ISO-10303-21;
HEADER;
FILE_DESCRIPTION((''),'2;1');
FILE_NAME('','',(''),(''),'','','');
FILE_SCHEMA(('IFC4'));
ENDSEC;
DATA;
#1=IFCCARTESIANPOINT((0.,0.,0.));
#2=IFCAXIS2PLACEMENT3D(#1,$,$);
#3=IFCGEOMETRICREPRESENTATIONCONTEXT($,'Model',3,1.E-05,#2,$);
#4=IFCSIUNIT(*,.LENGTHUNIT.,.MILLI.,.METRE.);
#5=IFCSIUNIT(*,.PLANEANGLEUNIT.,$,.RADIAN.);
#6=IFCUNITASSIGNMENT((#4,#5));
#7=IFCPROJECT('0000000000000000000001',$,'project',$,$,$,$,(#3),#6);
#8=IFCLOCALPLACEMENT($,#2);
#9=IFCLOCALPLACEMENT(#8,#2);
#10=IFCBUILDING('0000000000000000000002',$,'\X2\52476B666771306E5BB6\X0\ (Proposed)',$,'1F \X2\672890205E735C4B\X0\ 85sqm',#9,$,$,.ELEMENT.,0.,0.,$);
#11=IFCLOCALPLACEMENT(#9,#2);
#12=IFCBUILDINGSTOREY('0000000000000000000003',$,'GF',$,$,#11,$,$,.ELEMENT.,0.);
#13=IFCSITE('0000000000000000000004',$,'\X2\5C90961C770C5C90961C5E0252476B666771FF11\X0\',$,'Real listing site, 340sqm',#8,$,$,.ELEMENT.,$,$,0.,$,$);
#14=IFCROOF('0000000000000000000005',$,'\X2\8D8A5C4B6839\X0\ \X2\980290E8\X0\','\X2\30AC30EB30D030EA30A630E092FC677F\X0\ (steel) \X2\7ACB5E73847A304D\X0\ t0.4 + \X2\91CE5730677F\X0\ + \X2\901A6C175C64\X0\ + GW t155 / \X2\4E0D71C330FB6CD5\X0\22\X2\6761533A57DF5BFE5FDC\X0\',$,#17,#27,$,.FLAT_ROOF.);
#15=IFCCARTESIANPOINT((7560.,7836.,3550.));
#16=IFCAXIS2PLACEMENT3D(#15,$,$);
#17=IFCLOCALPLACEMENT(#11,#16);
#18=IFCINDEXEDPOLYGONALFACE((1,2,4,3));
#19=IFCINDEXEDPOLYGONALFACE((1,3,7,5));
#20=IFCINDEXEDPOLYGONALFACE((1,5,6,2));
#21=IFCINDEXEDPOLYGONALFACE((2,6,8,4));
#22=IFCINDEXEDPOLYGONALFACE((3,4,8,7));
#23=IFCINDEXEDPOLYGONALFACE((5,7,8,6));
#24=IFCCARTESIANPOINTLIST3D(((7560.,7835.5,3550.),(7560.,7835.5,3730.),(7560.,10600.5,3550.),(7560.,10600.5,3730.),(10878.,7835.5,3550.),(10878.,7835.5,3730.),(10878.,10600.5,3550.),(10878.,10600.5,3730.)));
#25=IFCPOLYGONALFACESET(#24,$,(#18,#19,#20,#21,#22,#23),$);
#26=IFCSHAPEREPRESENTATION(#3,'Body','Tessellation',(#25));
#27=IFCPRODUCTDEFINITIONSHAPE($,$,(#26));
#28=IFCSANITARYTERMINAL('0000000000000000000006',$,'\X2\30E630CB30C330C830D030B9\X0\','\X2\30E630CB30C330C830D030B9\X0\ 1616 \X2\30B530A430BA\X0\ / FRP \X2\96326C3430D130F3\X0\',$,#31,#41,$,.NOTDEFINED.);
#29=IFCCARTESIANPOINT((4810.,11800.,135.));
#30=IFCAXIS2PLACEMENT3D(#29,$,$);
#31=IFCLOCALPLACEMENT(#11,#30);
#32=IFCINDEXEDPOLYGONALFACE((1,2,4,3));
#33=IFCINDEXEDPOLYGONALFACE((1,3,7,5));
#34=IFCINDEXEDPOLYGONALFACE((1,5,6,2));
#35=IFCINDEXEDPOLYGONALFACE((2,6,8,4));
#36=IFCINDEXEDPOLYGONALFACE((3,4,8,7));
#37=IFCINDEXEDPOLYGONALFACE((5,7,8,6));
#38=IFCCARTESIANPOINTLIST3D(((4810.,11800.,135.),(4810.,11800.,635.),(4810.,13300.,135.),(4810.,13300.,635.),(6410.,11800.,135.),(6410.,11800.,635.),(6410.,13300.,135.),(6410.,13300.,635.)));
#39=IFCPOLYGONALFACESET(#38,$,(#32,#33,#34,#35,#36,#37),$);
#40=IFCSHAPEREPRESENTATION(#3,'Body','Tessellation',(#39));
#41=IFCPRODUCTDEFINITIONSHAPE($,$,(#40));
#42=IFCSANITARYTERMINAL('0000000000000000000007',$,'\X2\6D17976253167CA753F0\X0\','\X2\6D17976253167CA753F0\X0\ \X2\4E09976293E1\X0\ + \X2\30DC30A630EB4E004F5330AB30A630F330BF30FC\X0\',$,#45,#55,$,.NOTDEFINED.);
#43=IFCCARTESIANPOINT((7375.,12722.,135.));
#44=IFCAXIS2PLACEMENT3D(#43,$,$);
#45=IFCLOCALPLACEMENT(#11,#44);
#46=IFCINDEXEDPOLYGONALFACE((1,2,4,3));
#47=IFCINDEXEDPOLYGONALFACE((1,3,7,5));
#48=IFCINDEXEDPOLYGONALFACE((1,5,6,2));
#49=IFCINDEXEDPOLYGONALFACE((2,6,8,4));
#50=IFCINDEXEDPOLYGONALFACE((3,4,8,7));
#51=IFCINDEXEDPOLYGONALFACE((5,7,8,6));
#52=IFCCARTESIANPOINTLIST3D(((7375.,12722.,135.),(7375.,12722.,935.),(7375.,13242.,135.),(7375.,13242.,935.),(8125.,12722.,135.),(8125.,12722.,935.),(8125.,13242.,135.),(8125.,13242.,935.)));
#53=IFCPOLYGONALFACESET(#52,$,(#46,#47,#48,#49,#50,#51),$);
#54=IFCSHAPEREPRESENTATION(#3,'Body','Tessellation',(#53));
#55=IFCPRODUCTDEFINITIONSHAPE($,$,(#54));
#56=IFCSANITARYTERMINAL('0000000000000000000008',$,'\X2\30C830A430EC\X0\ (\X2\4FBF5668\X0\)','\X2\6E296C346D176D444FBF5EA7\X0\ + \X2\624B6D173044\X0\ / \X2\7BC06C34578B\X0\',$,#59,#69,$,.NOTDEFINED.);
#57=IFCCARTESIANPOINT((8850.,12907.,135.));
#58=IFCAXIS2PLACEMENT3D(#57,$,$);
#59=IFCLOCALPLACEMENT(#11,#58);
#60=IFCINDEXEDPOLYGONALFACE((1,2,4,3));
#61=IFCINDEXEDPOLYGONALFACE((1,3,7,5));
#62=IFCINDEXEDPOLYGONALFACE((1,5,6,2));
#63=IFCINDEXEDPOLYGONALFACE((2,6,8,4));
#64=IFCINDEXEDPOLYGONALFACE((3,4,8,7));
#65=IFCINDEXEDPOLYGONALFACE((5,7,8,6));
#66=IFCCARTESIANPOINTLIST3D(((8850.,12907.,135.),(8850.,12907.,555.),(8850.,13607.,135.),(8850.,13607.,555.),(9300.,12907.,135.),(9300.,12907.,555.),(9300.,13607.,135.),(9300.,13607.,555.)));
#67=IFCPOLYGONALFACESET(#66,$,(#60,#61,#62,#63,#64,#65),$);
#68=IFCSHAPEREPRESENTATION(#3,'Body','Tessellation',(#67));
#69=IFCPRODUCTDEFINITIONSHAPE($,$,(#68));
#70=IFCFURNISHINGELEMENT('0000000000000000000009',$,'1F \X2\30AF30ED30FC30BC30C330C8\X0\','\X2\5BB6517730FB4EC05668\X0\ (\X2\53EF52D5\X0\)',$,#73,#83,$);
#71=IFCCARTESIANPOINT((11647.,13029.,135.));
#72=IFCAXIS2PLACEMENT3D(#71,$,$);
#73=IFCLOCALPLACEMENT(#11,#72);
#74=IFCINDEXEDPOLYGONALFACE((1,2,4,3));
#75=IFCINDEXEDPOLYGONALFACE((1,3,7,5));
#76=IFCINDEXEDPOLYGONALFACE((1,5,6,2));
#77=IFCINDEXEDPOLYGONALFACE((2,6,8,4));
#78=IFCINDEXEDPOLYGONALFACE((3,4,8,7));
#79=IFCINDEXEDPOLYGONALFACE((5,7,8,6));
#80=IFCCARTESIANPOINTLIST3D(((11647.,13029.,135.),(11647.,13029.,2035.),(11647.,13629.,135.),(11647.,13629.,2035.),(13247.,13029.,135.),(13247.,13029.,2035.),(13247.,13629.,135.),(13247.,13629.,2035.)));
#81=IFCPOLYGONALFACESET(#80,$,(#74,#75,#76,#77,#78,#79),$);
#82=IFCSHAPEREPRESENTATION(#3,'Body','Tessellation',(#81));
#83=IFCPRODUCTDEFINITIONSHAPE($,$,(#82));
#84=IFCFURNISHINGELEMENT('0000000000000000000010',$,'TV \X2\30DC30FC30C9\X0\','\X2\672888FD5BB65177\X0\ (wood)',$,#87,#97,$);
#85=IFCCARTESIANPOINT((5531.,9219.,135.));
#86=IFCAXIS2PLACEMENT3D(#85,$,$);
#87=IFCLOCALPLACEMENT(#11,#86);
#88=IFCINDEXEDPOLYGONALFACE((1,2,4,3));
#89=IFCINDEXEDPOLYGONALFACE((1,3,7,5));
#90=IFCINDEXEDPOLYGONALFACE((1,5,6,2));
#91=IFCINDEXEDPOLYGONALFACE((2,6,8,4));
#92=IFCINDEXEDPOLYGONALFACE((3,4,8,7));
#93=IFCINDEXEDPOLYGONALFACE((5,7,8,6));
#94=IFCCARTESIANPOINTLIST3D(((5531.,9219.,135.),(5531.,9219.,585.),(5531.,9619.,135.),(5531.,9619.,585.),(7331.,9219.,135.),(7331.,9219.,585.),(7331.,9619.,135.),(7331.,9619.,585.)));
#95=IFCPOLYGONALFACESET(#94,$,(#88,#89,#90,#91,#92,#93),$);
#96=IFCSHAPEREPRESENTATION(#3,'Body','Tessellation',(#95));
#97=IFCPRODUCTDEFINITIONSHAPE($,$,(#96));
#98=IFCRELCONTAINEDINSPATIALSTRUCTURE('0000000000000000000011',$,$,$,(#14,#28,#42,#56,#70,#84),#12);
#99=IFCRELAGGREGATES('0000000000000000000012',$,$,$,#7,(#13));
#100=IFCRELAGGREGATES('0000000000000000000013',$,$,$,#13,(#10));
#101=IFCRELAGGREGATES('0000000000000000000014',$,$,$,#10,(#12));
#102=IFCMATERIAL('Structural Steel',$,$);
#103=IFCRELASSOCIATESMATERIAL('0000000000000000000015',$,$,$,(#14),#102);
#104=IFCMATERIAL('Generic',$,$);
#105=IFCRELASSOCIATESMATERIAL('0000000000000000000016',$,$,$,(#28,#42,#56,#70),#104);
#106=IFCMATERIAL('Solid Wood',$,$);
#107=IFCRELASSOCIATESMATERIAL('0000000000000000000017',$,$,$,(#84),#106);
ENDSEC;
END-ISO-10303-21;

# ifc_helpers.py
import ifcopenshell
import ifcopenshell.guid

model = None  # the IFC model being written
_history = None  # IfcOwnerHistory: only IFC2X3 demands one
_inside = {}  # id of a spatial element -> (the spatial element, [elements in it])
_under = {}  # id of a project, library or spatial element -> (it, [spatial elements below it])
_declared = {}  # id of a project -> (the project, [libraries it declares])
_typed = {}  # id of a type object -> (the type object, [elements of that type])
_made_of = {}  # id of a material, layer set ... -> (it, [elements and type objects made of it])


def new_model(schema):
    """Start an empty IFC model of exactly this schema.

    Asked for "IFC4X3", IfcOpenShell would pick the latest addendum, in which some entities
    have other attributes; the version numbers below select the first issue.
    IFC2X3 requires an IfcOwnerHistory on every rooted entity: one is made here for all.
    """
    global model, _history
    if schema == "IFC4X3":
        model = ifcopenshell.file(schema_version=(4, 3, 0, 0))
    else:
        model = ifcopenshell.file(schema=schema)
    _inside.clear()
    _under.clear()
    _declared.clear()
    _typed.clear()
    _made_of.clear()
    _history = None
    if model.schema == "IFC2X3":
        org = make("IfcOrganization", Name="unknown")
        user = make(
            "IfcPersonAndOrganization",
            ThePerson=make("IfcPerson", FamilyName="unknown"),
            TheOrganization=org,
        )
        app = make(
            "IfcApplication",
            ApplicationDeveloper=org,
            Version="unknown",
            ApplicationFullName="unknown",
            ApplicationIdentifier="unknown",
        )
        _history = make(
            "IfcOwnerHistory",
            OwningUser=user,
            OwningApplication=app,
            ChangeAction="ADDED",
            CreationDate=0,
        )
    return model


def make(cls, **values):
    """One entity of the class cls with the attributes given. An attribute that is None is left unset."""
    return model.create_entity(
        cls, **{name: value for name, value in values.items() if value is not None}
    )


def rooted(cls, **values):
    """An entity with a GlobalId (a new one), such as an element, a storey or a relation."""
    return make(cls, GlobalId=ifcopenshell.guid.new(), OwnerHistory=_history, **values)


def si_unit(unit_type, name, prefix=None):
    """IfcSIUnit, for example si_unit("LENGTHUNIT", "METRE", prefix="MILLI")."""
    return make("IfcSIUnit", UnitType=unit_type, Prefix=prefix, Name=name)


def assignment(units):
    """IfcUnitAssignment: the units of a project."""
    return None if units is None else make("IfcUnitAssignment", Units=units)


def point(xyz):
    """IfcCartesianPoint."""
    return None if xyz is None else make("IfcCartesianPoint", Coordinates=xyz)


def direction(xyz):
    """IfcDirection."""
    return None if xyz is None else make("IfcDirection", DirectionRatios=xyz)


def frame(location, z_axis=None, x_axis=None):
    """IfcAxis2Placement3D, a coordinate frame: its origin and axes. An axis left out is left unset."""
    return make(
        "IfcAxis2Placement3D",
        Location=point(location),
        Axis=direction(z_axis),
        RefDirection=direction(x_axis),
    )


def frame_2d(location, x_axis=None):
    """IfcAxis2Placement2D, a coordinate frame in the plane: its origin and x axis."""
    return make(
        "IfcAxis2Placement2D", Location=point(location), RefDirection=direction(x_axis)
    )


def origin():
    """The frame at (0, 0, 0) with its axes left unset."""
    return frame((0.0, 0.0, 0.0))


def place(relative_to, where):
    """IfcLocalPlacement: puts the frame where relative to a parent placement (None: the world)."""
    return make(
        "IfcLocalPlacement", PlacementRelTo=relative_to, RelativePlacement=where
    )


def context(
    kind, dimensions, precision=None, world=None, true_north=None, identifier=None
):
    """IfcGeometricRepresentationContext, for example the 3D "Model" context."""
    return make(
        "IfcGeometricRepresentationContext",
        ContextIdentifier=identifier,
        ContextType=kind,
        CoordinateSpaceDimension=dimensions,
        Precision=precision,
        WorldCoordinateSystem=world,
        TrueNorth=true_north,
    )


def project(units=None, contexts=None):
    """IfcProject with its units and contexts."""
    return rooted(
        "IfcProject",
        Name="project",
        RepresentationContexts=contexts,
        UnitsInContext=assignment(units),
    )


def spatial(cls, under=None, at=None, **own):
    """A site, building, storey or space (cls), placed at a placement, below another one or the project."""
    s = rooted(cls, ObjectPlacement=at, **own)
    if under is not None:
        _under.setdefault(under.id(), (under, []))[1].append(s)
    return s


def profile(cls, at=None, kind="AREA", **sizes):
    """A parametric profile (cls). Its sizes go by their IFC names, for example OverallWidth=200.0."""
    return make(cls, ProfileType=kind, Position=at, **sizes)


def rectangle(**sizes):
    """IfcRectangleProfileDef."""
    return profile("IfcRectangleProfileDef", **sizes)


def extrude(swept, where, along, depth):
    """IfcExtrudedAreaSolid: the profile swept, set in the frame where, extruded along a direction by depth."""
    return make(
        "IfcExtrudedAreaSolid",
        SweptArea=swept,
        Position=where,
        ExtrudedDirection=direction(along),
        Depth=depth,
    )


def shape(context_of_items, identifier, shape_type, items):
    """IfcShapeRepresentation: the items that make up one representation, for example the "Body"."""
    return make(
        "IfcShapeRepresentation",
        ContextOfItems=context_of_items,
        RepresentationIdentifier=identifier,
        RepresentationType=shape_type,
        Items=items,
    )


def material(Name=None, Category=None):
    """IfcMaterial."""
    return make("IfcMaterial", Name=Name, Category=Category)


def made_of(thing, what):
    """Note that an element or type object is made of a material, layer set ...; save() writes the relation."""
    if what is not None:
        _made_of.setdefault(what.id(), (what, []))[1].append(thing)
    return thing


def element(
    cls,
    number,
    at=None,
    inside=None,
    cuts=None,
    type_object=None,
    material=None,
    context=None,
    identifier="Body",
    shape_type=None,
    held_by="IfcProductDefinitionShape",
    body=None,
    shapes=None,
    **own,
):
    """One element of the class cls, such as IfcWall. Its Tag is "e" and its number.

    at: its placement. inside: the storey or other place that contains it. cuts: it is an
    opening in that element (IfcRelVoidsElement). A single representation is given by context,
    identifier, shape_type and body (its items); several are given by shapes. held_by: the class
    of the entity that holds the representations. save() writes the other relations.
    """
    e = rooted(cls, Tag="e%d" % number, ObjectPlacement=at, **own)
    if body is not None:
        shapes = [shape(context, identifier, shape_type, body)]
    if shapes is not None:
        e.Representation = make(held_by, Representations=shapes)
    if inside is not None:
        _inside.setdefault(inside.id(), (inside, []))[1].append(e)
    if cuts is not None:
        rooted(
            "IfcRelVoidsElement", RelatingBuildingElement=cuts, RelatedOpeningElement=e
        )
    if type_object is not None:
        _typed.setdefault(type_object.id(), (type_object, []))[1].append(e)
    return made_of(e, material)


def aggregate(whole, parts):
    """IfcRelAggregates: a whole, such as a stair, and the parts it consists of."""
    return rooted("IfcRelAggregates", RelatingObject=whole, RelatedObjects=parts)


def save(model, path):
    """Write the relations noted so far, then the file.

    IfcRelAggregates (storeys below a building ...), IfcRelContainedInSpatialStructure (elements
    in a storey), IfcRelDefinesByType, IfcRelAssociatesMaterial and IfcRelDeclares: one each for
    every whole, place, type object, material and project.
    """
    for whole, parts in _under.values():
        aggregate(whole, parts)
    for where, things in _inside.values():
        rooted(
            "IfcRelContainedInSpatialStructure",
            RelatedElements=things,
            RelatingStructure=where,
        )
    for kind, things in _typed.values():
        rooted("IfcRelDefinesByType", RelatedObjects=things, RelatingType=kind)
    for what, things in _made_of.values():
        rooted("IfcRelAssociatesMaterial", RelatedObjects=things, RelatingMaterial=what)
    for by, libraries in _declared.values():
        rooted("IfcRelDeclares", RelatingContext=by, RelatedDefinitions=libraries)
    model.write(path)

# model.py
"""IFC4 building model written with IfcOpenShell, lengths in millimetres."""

from ifc_helpers import new_model, si_unit, frame, frame_2d, origin, place, context, project, spatial, rectangle, extrude, material, element, save


model = new_model("IFC4")

# Units and contexts
model_context = context("Model", 3, precision=1e-05, world=origin())
ifc_project = project(units=[si_unit("LENGTHUNIT", "METRE", prefix="MILLI"), si_unit("PLANEANGLEUNIT", "RADIAN")], contexts=[model_context])

# Site, building, storey
site_placement = place(None, origin())
site = spatial("IfcSite", under=ifc_project, at=site_placement, Name="岐阜県岐阜市則武東１", ObjectType="Real listing site, 340sqm", CompositionType="ELEMENT", RefElevation=0.0)
building_placement = place(site_placement, origin())
building = spatial("IfcBuilding", under=site, at=building_placement, Name="則武東の家 (Proposed)", ObjectType="1F 木造平屋 85sqm", CompositionType="ELEMENT", ElevationOfRefHeight=0.0, ElevationOfTerrain=0.0)
storey_placement = place(building_placement, origin())
storey = spatial("IfcBuildingStorey", under=building, at=storey_placement, Name="GF", CompositionType="ELEMENT", Elevation=0.0)

# Shared definitions
ifc_material_1 = material(Name="Solid Wood")

# Roof
ifc_material_2 = material(Name="Structural Steel")
roof_placement = place(storey_placement, frame((7560.0, 7836.0, 3550.0)))
element("IfcRoof", 1, at=roof_placement, inside=storey, material=ifc_material_2, Name="越屋根 頂部", Description="ガルバリウム鋼板 (steel) 立平葺き t0.4 + 野地板 + 通気層 + GW t155 / 不燃・法22条区域対応", PredefinedType="FLAT_ROOF", context=model_context, shape_type="SweptSolid", body=[
    extrude(rectangle(XDim=3318.0, YDim=2765.0, at=frame_2d((1659.0, 1382.0))), frame((7560.0, 7836.0, 3550.0)), (0.0, 0.0, 1.0), 180.0),
])

# Sanitary terminals
ifc_material_3 = material(Name="Generic")
sanitary_terminal_1_placement = place(storey_placement, frame((4810.0, 11800.0, 135.0)))
element("IfcSanitaryTerminal", 2, at=sanitary_terminal_1_placement, inside=storey, material=ifc_material_3, Name="ユニットバス", Description="ユニットバス 1616 サイズ / FRP 防水パン", PredefinedType="NOTDEFINED", context=model_context, shape_type="SweptSolid", body=[
    extrude(rectangle(XDim=1600.0, YDim=1500.0, at=frame_2d((800.0, 750.0))), frame((4810.0, 11800.0, 135.0)), (0.0, 0.0, 1.0), 500.0),
])
sanitary_terminal_2_placement = place(storey_placement, frame((7375.0, 12722.0, 135.0)))
element("IfcSanitaryTerminal", 3, at=sanitary_terminal_2_placement, inside=storey, material=ifc_material_3, Name="洗面化粧台", Description="洗面化粧台 三面鏡 + ボウル一体カウンター", PredefinedType="NOTDEFINED", context=model_context, shape_type="SweptSolid", body=[
    extrude(rectangle(XDim=750.0, YDim=520.0, at=frame_2d((375.0, 260.0))), frame((7375.0, 12722.0, 135.0)), (0.0, 0.0, 1.0), 800.0),
])
sanitary_terminal_3_placement = place(storey_placement, frame((8850.0, 12907.0, 135.0)))
element("IfcSanitaryTerminal", 4, at=sanitary_terminal_3_placement, inside=storey, material=ifc_material_3, Name="トイレ (便器)", Description="温水洗浄便座 + 手洗い / 節水型", PredefinedType="NOTDEFINED", context=model_context, shape_type="SweptSolid", body=[
    extrude(rectangle(XDim=450.0, YDim=700.0, at=frame_2d((225.0, 350.0))), frame((8850.0, 12907.0, 135.0)), (0.0, 0.0, 1.0), 420.0),
])

# Furnishing elements
furnishing_1_placement = place(storey_placement, frame((11647.0, 13029.0, 135.0)))
element("IfcFurnishingElement", 5, at=furnishing_1_placement, inside=storey, material=ifc_material_3, Name="1F クローゼット", Description="家具・什器 (可動)", context=model_context, shape_type="SweptSolid", body=[
    extrude(rectangle(XDim=1600.0, YDim=600.0, at=frame_2d((800.0, 300.0))), frame((11647.0, 13029.0, 135.0)), (0.0, 0.0, 1.0), 1900.0),
])
furnishing_2_placement = place(storey_placement, frame((5531.0, 9219.0, 135.0)))
element("IfcFurnishingElement", 6, at=furnishing_2_placement, inside=storey, material=ifc_material_1, Name="TV ボード", Description="木製家具 (wood)", context=model_context, shape_type="SweptSolid", body=[
    extrude(rectangle(XDim=1800.0, YDim=400.0, at=frame_2d((900.0, 200.0))), frame((5531.0, 9219.0, 135.0)), (0.0, 0.0, 1.0), 450.0),
])

save(model, "model.ifc")
